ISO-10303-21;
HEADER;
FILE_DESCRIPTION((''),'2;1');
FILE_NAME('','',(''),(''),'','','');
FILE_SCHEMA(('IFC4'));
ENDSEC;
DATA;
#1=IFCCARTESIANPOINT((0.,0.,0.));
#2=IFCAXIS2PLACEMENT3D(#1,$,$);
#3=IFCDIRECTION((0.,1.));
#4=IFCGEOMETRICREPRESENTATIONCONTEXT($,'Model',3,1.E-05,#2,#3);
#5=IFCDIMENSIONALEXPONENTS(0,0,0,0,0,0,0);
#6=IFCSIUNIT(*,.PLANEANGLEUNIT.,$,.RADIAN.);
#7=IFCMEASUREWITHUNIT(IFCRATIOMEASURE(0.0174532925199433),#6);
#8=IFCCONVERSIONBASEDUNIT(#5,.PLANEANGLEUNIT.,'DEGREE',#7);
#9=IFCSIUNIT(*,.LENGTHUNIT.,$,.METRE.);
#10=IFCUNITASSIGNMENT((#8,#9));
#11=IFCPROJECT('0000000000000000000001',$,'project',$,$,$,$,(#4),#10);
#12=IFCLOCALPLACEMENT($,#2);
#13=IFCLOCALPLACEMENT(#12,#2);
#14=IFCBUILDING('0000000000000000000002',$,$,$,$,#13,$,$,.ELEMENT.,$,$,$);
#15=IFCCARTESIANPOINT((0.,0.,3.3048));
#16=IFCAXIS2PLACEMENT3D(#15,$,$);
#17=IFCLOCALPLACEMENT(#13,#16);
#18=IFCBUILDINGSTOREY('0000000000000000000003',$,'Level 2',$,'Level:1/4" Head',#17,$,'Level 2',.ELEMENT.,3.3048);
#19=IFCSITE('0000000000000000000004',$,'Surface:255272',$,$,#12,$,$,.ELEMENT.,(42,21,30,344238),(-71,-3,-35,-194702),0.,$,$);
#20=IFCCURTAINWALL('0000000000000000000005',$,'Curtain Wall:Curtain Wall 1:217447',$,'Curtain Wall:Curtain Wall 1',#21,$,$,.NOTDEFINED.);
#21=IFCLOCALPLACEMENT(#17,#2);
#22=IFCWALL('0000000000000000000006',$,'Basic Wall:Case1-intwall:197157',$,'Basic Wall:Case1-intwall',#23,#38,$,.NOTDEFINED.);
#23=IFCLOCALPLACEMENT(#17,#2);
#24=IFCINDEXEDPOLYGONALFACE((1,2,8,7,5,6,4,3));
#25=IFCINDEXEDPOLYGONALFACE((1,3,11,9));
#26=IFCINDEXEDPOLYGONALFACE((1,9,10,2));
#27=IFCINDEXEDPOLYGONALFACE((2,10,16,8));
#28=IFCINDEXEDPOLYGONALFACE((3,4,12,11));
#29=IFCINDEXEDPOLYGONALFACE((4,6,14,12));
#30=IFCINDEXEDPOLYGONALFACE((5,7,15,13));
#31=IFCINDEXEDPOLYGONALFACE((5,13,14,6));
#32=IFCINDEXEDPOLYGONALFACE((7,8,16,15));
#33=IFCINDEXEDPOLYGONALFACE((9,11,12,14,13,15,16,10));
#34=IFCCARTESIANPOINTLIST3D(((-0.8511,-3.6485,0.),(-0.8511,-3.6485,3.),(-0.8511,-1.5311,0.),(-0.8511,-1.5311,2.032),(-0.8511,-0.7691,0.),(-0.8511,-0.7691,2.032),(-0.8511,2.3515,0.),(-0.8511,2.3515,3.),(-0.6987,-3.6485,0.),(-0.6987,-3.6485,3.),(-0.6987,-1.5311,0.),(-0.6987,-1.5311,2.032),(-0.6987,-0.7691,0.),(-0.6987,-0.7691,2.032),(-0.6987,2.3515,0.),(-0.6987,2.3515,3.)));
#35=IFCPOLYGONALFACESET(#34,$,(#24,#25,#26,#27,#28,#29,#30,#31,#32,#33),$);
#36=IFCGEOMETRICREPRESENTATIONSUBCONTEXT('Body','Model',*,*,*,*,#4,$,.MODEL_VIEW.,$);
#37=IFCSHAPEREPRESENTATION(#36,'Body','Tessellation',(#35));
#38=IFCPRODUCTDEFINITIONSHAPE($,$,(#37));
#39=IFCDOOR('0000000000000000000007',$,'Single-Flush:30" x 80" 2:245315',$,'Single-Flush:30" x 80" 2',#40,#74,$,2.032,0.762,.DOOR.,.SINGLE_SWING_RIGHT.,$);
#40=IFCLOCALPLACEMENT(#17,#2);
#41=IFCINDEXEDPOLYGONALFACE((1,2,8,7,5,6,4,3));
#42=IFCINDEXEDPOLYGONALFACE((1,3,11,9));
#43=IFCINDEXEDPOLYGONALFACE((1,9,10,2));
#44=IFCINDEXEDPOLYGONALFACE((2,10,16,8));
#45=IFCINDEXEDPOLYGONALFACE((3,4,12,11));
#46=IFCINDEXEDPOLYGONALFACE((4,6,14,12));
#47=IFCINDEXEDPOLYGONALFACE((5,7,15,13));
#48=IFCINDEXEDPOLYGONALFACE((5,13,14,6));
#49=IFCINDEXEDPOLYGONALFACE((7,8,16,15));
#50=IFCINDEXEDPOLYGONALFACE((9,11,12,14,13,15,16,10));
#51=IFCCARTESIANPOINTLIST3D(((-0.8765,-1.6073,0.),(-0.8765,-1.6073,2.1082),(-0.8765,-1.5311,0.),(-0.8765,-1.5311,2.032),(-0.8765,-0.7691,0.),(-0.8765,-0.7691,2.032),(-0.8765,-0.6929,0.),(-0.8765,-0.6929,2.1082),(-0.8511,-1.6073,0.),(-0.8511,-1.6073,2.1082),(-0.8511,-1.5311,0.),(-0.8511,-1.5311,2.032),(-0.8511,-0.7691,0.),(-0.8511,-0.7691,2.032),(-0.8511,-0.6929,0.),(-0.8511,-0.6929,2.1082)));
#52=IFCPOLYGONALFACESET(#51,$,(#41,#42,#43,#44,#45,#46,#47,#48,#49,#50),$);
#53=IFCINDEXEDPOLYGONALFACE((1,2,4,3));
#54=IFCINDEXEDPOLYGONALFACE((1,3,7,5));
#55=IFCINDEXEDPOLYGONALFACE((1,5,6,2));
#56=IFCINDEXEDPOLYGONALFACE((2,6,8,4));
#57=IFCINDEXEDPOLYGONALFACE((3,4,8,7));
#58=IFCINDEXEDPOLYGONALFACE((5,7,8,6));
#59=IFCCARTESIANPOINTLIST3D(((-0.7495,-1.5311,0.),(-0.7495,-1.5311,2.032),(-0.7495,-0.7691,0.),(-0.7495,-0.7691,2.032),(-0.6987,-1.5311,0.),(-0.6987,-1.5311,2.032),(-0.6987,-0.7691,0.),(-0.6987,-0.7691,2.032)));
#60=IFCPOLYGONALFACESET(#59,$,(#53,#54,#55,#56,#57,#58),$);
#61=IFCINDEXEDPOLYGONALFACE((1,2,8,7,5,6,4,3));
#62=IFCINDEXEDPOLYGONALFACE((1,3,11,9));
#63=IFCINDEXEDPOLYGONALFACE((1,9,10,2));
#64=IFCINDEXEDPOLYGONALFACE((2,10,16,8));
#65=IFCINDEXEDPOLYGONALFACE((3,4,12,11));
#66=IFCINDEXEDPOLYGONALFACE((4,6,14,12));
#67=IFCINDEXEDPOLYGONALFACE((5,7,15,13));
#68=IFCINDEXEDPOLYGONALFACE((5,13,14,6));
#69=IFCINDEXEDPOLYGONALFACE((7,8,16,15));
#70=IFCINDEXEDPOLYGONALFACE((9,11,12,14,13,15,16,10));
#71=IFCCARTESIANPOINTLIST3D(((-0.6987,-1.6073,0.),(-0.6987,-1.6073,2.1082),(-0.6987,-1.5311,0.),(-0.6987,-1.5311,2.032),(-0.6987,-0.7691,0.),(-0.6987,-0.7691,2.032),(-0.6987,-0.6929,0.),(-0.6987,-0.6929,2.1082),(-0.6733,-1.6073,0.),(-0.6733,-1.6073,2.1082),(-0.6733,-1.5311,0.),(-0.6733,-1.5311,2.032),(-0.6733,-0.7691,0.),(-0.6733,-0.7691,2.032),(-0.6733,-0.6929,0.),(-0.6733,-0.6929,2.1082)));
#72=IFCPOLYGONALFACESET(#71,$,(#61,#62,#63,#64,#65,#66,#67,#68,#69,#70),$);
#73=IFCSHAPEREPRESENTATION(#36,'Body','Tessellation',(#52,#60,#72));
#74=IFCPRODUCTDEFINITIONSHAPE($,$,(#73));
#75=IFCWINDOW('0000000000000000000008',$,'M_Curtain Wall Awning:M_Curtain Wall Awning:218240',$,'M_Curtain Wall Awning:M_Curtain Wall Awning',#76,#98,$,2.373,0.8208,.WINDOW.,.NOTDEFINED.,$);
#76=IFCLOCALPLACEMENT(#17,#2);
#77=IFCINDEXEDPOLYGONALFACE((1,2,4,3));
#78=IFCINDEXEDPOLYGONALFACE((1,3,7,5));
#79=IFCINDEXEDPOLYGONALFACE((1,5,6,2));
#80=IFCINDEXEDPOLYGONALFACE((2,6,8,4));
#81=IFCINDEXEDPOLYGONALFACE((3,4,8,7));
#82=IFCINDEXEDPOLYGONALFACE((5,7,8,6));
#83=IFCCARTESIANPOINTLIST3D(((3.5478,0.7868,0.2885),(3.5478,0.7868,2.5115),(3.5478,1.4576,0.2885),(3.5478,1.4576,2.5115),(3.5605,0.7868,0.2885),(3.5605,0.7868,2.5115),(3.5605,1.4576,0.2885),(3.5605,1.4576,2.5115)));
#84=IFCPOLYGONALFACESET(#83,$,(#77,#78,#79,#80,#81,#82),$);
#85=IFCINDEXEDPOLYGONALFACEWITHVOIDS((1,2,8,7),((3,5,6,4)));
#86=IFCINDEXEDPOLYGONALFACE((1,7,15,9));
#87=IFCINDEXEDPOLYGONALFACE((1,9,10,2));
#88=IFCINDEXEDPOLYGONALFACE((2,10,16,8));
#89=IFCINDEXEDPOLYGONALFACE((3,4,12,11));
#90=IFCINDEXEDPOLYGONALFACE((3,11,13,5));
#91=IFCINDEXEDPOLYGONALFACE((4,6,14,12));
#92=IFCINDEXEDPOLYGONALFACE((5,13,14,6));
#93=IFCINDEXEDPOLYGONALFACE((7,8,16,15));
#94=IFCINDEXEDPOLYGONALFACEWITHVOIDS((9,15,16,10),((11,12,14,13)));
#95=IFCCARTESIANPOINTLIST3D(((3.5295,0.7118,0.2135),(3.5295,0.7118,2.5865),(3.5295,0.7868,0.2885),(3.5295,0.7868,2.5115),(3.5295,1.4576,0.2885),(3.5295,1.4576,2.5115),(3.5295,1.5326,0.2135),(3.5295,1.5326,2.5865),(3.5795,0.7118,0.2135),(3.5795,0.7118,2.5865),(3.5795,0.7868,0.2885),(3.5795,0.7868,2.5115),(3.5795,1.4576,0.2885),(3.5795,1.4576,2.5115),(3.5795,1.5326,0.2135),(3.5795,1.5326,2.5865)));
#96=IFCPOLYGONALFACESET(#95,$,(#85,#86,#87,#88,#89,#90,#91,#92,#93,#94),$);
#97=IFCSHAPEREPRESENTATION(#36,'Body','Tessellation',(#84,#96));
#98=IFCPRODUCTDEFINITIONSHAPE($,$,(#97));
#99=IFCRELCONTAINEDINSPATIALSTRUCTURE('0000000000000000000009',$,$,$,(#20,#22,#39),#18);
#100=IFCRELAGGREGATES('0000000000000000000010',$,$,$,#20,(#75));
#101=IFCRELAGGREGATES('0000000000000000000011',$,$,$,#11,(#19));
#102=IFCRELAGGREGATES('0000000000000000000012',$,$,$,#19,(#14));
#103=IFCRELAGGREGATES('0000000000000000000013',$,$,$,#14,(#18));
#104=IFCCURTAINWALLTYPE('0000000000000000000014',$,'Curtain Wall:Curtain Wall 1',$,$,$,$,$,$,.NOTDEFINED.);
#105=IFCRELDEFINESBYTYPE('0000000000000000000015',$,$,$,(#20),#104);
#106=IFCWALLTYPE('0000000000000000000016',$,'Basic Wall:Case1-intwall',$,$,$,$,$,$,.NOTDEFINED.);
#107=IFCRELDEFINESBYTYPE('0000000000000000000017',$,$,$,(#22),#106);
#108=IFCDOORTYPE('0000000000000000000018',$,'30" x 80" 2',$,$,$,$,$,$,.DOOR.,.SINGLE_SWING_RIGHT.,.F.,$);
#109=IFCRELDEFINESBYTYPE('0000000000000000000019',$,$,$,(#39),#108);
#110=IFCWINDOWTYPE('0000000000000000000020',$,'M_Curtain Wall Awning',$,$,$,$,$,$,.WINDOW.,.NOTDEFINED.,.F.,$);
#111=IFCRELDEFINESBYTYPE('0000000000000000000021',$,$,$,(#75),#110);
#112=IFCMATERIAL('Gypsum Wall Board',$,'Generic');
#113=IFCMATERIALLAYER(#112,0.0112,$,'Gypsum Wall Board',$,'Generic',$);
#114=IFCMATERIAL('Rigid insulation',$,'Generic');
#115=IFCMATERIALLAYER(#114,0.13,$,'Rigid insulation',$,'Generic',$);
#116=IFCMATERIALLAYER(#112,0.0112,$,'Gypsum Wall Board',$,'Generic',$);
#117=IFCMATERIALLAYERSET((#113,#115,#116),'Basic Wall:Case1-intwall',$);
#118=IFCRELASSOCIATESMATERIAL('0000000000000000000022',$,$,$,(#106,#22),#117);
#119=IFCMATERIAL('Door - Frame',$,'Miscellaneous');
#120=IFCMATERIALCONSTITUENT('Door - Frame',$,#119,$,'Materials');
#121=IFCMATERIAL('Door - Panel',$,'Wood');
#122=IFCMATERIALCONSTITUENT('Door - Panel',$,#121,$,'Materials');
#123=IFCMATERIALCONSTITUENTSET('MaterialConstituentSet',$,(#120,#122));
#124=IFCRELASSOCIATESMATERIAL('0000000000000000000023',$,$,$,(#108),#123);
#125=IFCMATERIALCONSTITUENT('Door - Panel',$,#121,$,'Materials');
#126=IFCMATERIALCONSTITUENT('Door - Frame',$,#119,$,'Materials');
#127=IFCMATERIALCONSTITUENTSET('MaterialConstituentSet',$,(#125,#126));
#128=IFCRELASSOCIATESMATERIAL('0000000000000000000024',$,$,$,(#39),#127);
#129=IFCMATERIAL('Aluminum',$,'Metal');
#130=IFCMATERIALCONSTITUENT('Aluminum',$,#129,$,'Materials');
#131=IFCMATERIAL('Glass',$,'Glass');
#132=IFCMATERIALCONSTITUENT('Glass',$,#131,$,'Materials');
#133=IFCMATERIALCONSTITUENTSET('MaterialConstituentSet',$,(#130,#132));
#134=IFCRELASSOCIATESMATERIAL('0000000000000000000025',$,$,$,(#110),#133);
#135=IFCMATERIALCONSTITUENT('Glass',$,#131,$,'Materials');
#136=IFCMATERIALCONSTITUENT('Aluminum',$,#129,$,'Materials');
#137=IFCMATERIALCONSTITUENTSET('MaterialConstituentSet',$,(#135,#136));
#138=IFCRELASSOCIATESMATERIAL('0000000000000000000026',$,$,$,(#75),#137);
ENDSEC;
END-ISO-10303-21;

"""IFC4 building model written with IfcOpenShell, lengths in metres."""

from ifc_helpers import new_model, entity, si_unit, converted_unit, direction, frame, frame_2d, origin, origin_2d_with_axis, place, context, subcontext, project, spatial, polyline, rectangle, outline, extrude, source, transform, mapped, material, layer, layer_set, layer_usage, constituent, constituent_set, type_object, type_shapes, element, fill, aggregate, save


model = new_model("IFC4")

# Units and contexts
model_context = context("Model", 3, precision=1e-05, world=origin(), true_north=direction((0.0, 1.0)))
body_context = subcontext(model_context, "Body", "Model", "MODEL_VIEW")
ifc_project = project(units=[converted_unit("PLANEANGLEUNIT", "DEGREE", entity("IfcRatioMeasure", 0.0174532925199433), si_unit("PLANEANGLEUNIT", "RADIAN"), dimensions=[0, 0, 0, 0, 0, 0, 0]), si_unit("LENGTHUNIT", "METRE")], contexts=[model_context])

# Site, building, storey
site_placement = place(None, origin())
site = spatial("IfcSite", under=ifc_project, at=site_placement, Name="Surface:255272", CompositionType="ELEMENT", RefLatitude=(42, 21, 30, 344238), RefLongitude=(-71, -3, -35, -194702), RefElevation=0.0)
building_placement = place(site_placement, origin())
building = spatial("IfcBuilding", under=site, at=building_placement, CompositionType="ELEMENT")
storey_placement = place(building_placement, frame((0.0, 0.0, 3.3048)))
storey = spatial("IfcBuildingStorey", under=building, at=storey_placement, Name="Level 2", ObjectType="Level:1/4\" Head", LongName="Level 2", CompositionType="ELEMENT", Elevation=3.3048)

# Curtain wall
curtain_wall_type = type_object("IfcCurtainWallType", Name="Curtain Wall:Curtain Wall 1", PredefinedType="NOTDEFINED")
ifc_material_1 = material(Name="Aluminum", Category="Metal")
curtain_wall_1_placement = place(storey_placement, frame((0.0, 0.0, -3.3048)))
curtain_wall_1 = element("IfcCurtainWall", 1, at=curtain_wall_1_placement, inside=storey, type_object=curtain_wall_type, Name="Curtain Wall:Curtain Wall 1:217447", ObjectType="Curtain Wall:Curtain Wall 1", PredefinedType="NOTDEFINED")

# Shared definitions
ifc_material_2 = material(Name="Glass", Category="Glass")

# Wall, opening, door
ifc_material_3 = material(Name="Gypsum Wall Board", Category="Generic")
ifc_layer_1 = layer(ifc_material_3, 0.0112, Name="Gypsum Wall Board", Category="Generic")
ifc_material_4 = material(Name="Rigid insulation", Category="Generic")
ifc_layer_2 = layer(ifc_material_4, 0.13, Name="Rigid insulation", Category="Generic")
ifc_layer_3 = layer(ifc_material_3, 0.0112, Name="Gypsum Wall Board", Category="Generic")
ifc_layer_set_1 = layer_set([ifc_layer_1, ifc_layer_2, ifc_layer_3], Name="Basic Wall:Case1-intwall")
ifc_layer_usage_1 = layer_usage(ifc_layer_set_1, "AXIS2", "NEGATIVE", 0.0762)
wall_type = type_object("IfcWallType", Name="Basic Wall:Case1-intwall", PredefinedType="NOTDEFINED", material=ifc_layer_set_1)
wall_placement = place(storey_placement, frame((-0.7749, 2.3515, 0.0), z_axis=(0.0, 0.0, 1.0), x_axis=(-0.000007, -1.0, 0.0)))
wall = element("IfcWall", 2, at=wall_placement, inside=storey, type_object=wall_type, material=ifc_layer_usage_1, Name="Basic Wall:Case1-intwall:197157", ObjectType="Basic Wall:Case1-intwall", PredefinedType="NOTDEFINED", context=body_context, shape_type="SweptSolid", body=[
    extrude(rectangle(XDim=6.0, YDim=0.1524, at=frame_2d((3.0, 0.0), x_axis=(-1.0, 0.0))), origin(), (0.0, 0.0, 1.0), 3.0),
])
opening_placement = place(wall_placement, frame((3.1206, -0.0762, 0.0)))
opening = element("IfcOpeningElement", 3, at=opening_placement, cuts=wall, ObjectType="Opening", PredefinedType="OPENING", context=body_context, shape_type="SweptSolid", body=[
    extrude(rectangle(XDim=0.762, YDim=2.032, at=frame_2d((1.016, 0.381), x_axis=(0.0, 1.0))), frame((0.0, 0.0, 0.0), z_axis=(0.000007, 1.0, 0.0), x_axis=(0.0, 0.0, 1.0)), (0.0, 0.0, 1.0), 0.1524),
])
ifc_material_5 = material(Name="Door - Panel", Category="Wood")
ifc_constituent_1 = constituent(ifc_material_5, Name="Door - Panel", Category="Materials")
ifc_material_6 = material(Name="Door - Frame", Category="Miscellaneous")
ifc_constituent_2 = constituent(ifc_material_6, Name="Door - Frame", Category="Materials")
ifc_constituent_set_1 = constituent_set(constituents=[ifc_constituent_1, ifc_constituent_2], Name="MaterialConstituentSet")
ifc_constituent_3 = constituent(ifc_material_6, Name="Door - Frame", Category="Materials")
ifc_constituent_4 = constituent(ifc_material_5, Name="Door - Panel", Category="Materials")
ifc_constituent_set_2 = constituent_set(constituents=[ifc_constituent_3, ifc_constituent_4], Name="MaterialConstituentSet")
door_type = type_object("IfcDoorType", Name="30\" x 80\" 2", OperationType="SINGLE_SWING_RIGHT", ParameterTakesPrecedence=False, PredefinedType="DOOR", material=ifc_constituent_set_2)
shared_shape_1 = source(origin(), body_context, "Body", "SweptSolid", [
    extrude(outline(polyline([(-1.0732, -0.4572), (1.0351, -0.4572), (1.0351, -0.381), (-0.997, -0.381), (-0.997, 0.381), (1.0351, 0.381), (1.0351, 0.4572), (-1.0732, 0.4572), (-1.0732, -0.4572)])), frame((0.381, -0.0254, 1.0351), z_axis=(0.0, 1.0, 0.0), x_axis=(0.0, 0.0, -1.0)), (0.0, 0.0, 1.0), 0.0254),
    extrude(rectangle(XDim=0.0508, YDim=0.762, at=origin_2d_with_axis()), frame((0.381, 0.127, 0.0), z_axis=(0.0, 0.0, 1.0), x_axis=(0.0, 1.0, 0.0)), (0.0, 0.0, 1.0), 2.032),
    extrude(outline(polyline([(-0.4572, -1.0732), (0.4572, -1.0732), (0.4572, 1.0351), (0.381, 1.0351), (0.381, -0.997), (-0.381, -0.997), (-0.381, 1.0351), (-0.4572, 1.0351), (-0.4572, -1.0732)])), frame((0.381, 0.1524, 1.0351), z_axis=(0.0, 1.0, 0.0), x_axis=(1.0, 0.0, 0.0)), (0.0, 0.0, 1.0), 0.0254),
])
type_shapes(door_type, [shared_shape_1])
door_placement = place(opening_placement, frame((0.0, 0.0, 0.0)))
door = element("IfcDoor", 4, at=door_placement, inside=storey, type_object=door_type, material=ifc_constituent_set_1, Name="Single-Flush:30\" x 80\" 2:245315", ObjectType="Single-Flush:30\" x 80\" 2", OperationType="SINGLE_SWING_RIGHT", OverallHeight=2.032, OverallWidth=0.762, PredefinedType="DOOR", context=body_context, shape_type="MappedRepresentation", body=[
    mapped(shared_shape_1, transform((0.0, 0.0, 0.0), scale=1.0)),
])
fill(opening, door)

# Window
ifc_constituent_5 = constituent(ifc_material_2, Name="Glass", Category="Materials")
ifc_constituent_6 = constituent(ifc_material_1, Name="Aluminum", Category="Materials")
ifc_constituent_set_3 = constituent_set(constituents=[ifc_constituent_5, ifc_constituent_6], Name="MaterialConstituentSet")
ifc_constituent_7 = constituent(ifc_material_1, Name="Aluminum", Category="Materials")
ifc_constituent_8 = constituent(ifc_material_2, Name="Glass", Category="Materials")
ifc_constituent_set_4 = constituent_set(constituents=[ifc_constituent_7, ifc_constituent_8], Name="MaterialConstituentSet")
window_type = type_object("IfcWindowType", Name="M_Curtain Wall Awning", ParameterTakesPrecedence=False, PartitioningType="NOTDEFINED", PredefinedType="WINDOW", material=ifc_constituent_set_4)
shared_shape_2 = source(origin(), body_context, "Body", "SweptSolid", [
    extrude(rectangle(XDim=0.0127, YDim=0.6708, at=frame_2d((0.0, 0.0), x_axis=(1.0, 0.0))), frame((0.0, 0.0504, 0.075), z_axis=(0.0, 0.0, 1.0), x_axis=(0.0, 1.0, 0.0)), (0.0, 0.0, 1.0), 2.223),
    extrude(outline(polyline([(-0.4104, -1.1865), (0.4104, -1.1865), (0.4104, 1.1865), (-0.4104, 1.1865), (-0.4104, -1.1865)]), holes=[polyline([(-0.3354, -1.1115), (-0.3354, 1.1115), (0.3354, 1.1115), (0.3354, -1.1115), (-0.3354, -1.1115)])]), frame((0.0, 0.025, 1.1865), z_axis=(0.0, 1.0, 0.0), x_axis=(1.0, 0.0, 0.0)), (0.0, 0.0, 1.0), 0.05),
])
type_shapes(window_type, [shared_shape_2])
window_placement = place(curtain_wall_1_placement, frame((3.6045, 1.1222, 3.5183), z_axis=(0.0, 0.0, 1.0), x_axis=(0.0, 1.0, 0.0)))
window = element("IfcWindow", 5, at=window_placement, type_object=window_type, material=ifc_constituent_set_3, Name="M_Curtain Wall Awning:M_Curtain Wall Awning:218240", ObjectType="M_Curtain Wall Awning:M_Curtain Wall Awning", OverallHeight=2.373, OverallWidth=0.8208, PartitioningType="NOTDEFINED", PredefinedType="WINDOW", context=body_context, shape_type="MappedRepresentation", body=[
    mapped(shared_shape_2, transform((0.0, 0.0, 0.0), scale=1.0)),
])
aggregate(curtain_wall_1, [window])

save(model, "model.ifc")
